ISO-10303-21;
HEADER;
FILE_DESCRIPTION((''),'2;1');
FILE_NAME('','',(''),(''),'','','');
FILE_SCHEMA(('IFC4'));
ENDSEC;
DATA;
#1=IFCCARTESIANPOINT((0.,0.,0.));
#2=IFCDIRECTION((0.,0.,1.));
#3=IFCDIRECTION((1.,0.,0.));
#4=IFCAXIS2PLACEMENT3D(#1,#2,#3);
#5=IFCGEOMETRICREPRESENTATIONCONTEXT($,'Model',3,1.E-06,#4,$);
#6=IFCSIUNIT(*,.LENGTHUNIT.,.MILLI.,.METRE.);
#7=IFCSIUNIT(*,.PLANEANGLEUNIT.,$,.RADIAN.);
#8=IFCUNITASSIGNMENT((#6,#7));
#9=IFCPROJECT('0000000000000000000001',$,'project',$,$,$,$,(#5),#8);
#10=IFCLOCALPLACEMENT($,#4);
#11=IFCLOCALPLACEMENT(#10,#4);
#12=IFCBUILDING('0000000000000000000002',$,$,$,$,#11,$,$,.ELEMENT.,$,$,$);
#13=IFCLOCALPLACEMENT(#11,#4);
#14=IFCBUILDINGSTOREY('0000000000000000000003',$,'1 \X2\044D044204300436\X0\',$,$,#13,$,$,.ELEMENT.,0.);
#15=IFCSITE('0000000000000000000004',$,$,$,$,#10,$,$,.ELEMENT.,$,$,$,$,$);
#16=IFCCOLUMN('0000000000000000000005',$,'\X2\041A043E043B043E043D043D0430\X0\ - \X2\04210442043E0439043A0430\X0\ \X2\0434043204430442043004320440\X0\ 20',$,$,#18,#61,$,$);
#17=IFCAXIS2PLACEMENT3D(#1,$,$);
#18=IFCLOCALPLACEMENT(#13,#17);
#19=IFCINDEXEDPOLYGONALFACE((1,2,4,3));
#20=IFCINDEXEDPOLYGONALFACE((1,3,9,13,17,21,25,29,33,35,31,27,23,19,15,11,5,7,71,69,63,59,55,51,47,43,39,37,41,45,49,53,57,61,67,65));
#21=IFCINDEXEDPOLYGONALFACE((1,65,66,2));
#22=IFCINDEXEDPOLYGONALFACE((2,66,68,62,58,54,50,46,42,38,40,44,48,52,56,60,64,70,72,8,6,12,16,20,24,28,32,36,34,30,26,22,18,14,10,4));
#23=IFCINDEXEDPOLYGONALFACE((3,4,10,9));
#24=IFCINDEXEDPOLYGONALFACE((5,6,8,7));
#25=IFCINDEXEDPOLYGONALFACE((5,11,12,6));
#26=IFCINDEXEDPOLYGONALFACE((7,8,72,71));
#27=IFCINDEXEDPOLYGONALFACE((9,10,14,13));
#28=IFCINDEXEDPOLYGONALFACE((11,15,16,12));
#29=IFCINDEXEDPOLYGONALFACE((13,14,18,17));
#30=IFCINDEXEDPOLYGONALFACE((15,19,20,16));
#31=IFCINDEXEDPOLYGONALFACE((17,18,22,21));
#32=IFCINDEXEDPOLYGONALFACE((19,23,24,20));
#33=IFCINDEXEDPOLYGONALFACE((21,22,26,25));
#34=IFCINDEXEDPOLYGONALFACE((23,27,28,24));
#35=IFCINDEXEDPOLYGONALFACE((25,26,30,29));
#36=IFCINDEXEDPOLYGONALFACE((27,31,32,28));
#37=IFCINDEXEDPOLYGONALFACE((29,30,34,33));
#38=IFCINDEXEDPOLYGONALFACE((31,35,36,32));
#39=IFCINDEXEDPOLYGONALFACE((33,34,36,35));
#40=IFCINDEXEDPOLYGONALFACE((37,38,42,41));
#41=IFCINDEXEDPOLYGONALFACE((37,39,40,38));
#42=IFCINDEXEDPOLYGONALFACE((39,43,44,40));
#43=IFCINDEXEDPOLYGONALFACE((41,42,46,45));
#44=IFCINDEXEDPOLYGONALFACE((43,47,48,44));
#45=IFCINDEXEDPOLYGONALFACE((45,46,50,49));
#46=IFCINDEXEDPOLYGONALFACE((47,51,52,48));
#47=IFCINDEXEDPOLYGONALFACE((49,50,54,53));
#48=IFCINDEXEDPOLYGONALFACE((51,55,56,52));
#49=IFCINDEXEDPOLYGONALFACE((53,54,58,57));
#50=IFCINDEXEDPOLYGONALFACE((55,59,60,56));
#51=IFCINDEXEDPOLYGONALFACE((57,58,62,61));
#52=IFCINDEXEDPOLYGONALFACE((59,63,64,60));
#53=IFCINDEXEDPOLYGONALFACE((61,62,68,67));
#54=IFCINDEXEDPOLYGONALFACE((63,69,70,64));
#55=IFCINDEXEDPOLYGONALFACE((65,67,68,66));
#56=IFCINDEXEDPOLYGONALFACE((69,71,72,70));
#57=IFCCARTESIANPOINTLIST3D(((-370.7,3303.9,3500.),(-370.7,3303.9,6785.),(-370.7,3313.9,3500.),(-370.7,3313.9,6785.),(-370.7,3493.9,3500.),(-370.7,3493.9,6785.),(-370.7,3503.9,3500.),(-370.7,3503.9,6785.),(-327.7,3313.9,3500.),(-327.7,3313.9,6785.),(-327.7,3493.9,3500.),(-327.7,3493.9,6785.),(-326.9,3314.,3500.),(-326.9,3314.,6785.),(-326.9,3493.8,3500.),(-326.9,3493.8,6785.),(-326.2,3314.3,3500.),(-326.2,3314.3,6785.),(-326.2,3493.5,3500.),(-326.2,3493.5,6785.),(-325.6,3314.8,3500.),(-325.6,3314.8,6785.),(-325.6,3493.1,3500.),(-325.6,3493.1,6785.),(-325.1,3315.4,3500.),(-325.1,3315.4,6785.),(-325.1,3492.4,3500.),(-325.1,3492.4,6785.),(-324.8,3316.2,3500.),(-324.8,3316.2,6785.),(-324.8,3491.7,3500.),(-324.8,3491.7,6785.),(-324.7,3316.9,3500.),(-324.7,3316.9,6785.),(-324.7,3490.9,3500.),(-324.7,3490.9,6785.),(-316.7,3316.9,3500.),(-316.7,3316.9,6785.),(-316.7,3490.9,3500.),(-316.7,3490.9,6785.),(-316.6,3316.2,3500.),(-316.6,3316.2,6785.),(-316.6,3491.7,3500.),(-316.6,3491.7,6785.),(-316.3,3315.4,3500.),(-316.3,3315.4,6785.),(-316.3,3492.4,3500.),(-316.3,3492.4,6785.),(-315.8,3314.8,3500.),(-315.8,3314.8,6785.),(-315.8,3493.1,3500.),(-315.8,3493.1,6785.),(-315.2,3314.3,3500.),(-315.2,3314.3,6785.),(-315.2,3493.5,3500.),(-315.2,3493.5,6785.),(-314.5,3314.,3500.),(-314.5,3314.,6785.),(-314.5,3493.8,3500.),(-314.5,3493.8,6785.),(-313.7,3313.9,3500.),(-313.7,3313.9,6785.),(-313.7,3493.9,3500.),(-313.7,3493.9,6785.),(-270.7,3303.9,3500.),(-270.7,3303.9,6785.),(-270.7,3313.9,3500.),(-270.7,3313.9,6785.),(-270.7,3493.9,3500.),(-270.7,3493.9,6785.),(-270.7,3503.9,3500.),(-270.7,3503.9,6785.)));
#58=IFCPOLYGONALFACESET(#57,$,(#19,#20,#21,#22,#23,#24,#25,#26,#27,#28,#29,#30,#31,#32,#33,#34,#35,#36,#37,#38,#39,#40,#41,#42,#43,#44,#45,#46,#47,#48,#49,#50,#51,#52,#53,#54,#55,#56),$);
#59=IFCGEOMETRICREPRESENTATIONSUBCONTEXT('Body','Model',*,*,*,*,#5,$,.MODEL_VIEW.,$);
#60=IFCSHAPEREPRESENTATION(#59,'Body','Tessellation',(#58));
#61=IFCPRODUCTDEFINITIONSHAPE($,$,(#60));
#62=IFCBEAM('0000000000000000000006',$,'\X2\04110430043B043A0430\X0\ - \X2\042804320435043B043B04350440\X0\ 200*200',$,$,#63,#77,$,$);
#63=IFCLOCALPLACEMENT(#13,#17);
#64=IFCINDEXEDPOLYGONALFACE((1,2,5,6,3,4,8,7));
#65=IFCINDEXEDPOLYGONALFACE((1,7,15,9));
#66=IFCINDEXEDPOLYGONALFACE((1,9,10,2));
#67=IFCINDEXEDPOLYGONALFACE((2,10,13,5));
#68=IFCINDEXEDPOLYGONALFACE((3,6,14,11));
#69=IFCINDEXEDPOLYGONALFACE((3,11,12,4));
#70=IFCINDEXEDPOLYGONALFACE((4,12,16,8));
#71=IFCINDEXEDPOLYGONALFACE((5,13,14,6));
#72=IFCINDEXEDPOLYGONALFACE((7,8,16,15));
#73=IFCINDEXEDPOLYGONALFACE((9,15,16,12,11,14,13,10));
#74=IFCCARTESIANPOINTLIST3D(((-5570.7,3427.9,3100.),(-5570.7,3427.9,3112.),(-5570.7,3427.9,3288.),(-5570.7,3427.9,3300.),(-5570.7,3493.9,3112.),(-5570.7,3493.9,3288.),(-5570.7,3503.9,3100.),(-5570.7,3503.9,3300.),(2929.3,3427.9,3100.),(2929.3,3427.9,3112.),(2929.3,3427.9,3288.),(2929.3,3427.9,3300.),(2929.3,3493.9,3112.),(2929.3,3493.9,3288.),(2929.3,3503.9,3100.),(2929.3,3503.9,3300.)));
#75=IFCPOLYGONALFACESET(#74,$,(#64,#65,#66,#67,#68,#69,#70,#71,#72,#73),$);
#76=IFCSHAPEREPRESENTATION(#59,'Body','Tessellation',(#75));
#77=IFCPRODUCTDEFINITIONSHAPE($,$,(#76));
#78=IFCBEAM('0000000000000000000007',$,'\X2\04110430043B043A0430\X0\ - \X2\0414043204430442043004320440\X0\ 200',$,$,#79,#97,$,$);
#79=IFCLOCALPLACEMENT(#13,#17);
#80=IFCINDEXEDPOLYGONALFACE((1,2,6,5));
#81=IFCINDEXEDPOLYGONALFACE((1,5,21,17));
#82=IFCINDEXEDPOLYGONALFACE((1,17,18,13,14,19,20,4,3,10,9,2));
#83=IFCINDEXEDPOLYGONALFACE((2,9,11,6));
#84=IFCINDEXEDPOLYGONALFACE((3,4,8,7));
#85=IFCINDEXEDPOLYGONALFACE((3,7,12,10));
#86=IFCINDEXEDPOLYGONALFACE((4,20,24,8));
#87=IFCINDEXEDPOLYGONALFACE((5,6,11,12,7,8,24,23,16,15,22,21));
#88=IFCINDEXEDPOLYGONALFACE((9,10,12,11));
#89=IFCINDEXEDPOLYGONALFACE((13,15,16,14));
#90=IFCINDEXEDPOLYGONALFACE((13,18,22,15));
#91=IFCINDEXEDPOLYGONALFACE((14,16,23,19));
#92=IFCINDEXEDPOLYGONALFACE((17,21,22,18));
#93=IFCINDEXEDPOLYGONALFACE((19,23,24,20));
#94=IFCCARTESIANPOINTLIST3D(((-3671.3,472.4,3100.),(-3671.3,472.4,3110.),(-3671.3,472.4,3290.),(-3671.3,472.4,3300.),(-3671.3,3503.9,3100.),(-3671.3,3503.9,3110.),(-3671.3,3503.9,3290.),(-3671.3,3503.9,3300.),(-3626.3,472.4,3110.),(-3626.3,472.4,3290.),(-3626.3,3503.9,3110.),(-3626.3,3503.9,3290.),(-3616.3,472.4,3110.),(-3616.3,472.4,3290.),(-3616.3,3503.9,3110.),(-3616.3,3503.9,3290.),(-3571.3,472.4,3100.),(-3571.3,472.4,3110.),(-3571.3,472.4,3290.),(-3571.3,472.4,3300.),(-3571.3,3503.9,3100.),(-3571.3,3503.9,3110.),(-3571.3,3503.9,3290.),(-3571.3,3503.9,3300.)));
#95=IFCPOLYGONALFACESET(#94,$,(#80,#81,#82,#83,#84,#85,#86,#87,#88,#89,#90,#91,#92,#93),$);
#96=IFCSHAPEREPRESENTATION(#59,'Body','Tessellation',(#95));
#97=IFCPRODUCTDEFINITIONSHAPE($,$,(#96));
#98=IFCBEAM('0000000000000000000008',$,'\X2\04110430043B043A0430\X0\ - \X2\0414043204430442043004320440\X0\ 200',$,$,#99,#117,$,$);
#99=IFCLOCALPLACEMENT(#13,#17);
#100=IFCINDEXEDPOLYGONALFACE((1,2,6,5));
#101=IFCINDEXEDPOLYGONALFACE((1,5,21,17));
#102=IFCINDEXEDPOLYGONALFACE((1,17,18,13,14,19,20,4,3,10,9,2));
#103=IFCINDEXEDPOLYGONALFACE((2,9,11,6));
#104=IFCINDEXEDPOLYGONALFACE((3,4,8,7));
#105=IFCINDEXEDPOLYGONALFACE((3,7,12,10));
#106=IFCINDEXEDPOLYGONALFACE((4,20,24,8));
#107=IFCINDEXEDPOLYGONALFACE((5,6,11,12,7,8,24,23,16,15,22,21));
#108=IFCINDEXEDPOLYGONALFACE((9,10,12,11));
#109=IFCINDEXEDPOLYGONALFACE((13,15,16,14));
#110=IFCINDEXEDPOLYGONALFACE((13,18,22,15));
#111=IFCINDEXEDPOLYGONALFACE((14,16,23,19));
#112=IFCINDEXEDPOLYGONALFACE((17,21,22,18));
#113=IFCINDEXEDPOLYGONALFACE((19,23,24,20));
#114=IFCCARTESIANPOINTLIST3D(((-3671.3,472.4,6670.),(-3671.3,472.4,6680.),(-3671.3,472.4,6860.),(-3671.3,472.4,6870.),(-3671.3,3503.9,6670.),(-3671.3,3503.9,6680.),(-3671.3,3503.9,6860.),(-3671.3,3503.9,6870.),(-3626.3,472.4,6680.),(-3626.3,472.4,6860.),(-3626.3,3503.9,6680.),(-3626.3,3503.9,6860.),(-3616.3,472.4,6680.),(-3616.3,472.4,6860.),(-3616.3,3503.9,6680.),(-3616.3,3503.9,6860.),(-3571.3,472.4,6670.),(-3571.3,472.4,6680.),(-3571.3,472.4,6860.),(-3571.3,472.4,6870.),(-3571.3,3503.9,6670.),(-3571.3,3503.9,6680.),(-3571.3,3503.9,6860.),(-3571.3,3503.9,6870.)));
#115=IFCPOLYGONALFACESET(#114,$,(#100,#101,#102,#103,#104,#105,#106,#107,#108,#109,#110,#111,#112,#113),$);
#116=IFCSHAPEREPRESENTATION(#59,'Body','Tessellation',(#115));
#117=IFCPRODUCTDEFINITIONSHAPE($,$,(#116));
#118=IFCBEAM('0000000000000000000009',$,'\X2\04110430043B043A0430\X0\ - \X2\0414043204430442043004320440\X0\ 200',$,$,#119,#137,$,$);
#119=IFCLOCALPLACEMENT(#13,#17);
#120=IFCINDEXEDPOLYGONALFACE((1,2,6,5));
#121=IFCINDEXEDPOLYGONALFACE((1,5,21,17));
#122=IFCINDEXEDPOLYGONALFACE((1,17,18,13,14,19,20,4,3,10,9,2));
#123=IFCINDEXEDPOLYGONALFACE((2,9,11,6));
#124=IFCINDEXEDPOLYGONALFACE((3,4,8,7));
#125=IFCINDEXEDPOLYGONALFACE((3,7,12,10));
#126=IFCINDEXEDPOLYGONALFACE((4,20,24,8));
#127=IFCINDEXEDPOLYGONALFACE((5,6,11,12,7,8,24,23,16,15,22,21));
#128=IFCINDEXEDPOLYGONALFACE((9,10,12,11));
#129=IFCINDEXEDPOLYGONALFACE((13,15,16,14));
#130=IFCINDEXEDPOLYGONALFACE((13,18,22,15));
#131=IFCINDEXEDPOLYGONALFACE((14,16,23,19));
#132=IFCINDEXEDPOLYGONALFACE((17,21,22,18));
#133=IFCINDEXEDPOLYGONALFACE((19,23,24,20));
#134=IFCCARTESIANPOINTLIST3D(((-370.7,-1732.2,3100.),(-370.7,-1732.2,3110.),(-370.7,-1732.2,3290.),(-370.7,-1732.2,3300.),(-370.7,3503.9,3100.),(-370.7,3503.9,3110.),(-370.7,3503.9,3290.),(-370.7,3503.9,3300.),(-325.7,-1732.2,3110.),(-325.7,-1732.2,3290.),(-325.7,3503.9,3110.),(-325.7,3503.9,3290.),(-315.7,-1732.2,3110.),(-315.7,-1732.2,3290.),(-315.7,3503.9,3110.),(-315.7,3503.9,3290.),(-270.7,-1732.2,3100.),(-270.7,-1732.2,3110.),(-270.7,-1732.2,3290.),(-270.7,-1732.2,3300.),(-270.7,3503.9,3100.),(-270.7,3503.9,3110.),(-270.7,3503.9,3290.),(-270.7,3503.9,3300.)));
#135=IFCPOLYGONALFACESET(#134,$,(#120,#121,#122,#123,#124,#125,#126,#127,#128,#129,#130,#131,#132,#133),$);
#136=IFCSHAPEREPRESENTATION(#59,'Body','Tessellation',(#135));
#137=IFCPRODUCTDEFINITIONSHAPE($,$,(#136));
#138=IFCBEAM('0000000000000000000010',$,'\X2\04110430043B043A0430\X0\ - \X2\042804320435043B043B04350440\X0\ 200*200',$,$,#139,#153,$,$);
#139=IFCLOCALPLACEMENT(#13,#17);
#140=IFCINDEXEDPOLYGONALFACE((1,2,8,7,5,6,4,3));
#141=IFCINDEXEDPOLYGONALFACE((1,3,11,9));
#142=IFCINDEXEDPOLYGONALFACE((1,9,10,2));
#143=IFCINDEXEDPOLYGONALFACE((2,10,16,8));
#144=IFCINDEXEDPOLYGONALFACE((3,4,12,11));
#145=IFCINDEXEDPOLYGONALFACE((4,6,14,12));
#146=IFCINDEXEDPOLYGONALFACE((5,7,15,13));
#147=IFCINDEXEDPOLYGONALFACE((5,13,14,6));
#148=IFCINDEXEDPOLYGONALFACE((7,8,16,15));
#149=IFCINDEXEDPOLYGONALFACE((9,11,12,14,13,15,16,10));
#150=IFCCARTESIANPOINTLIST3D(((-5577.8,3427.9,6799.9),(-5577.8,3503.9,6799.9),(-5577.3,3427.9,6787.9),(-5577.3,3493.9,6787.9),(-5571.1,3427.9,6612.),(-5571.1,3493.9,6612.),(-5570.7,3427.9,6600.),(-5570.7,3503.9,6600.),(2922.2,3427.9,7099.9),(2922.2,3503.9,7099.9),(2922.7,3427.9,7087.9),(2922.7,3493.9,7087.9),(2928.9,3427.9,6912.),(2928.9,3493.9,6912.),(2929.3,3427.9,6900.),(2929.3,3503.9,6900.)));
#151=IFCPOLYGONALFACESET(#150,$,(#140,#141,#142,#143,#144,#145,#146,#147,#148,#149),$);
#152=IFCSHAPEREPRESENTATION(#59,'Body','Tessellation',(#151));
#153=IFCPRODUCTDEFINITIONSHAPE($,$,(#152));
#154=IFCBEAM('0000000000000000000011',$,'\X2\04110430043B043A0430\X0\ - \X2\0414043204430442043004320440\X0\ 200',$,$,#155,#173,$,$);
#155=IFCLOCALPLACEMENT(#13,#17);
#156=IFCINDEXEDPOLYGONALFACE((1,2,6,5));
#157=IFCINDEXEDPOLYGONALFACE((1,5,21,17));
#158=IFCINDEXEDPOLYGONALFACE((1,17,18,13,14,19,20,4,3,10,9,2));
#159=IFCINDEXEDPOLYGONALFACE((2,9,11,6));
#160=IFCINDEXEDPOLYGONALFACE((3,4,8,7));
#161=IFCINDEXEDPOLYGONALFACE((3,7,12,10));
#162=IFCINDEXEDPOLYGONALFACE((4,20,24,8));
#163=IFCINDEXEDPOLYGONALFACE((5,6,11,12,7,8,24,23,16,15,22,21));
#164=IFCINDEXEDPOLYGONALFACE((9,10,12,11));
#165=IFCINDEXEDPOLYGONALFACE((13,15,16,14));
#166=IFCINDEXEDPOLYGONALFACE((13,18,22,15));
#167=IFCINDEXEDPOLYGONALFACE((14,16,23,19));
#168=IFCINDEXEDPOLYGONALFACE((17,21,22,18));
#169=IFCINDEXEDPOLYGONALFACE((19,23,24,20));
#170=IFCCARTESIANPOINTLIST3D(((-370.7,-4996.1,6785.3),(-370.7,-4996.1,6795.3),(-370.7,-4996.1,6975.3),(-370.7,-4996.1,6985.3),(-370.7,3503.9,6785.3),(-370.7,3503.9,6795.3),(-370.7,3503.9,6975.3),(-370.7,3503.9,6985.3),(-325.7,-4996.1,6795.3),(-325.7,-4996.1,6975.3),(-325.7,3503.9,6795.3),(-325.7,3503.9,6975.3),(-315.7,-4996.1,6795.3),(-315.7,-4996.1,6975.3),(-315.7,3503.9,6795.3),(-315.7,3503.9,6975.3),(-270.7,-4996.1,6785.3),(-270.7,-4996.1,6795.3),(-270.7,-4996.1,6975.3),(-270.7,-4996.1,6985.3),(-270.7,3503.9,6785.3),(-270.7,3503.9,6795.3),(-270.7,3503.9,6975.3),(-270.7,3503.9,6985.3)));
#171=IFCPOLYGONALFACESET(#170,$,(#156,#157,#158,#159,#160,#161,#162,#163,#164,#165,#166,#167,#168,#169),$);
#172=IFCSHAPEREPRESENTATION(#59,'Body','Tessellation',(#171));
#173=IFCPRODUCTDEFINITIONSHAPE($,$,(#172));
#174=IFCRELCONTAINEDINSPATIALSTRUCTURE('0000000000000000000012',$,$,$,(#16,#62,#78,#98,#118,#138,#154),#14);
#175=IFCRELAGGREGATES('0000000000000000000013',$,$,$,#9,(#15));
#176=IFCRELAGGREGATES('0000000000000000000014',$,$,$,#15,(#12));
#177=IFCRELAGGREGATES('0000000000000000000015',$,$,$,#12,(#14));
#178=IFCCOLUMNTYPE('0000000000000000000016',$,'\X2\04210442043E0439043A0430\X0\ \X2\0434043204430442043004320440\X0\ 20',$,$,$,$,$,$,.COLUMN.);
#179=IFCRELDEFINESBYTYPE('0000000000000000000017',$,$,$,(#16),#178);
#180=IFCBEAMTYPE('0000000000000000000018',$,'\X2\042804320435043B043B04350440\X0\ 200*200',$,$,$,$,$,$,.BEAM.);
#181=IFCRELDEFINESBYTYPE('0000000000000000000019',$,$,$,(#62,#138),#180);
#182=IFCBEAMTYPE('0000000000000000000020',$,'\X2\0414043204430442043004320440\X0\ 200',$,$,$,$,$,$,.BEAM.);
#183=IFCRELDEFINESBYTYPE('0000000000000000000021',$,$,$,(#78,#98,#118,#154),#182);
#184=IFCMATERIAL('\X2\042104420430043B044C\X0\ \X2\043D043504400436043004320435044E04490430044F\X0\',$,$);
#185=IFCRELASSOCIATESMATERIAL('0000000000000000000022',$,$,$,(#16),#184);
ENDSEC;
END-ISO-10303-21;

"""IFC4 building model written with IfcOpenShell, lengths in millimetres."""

from ifc_helpers import new_model, si_unit, frame, origin_with_axes, place, context, subcontext, project, spatial, line, arc, indexed_curve, outline, extrude, source, transform, mapped, material, type_object, element, save


model = new_model("IFC4")

# Units and contexts
model_context = context("Model", 3, precision=1e-06, world=origin_with_axes())
body_context = subcontext(model_context, "Body", "Model", "MODEL_VIEW")
ifc_project = project(units=[si_unit("LENGTHUNIT", "METRE", prefix="MILLI"), si_unit("PLANEANGLEUNIT", "RADIAN")], contexts=[model_context])

# Site, building, storey
site_placement = place(None, origin_with_axes())
site = spatial("IfcSite", under=ifc_project, at=site_placement, CompositionType="ELEMENT")
building_placement = place(site_placement, origin_with_axes())
building = spatial("IfcBuilding", under=site, at=building_placement, CompositionType="ELEMENT")
storey_placement = place(building_placement, origin_with_axes())
storey = spatial("IfcBuildingStorey", under=building, at=storey_placement, Name="1 этаж", CompositionType="ELEMENT", Elevation=0.0)

# Column
ifc_material_1 = material(Name="Сталь нержавеющая")
column_type = type_object("IfcColumnType", Name="Стойка двутавр 20", PredefinedType="COLUMN")
shared_shape_1 = source(origin_with_axes(), body_context, "Body", "SweptSolid", [
    extrude(outline(indexed_curve([(-50.0, -100.0), (50.0, -100.0), (50.0, -90.0), (7.0, -90.0), (4.9, -89.1), (4.0, -87.0), (4.0, 87.0), (4.9, 89.1), (7.0, 90.0), (50.0, 90.0), (50.0, 100.0), (-50.0, 100.0), (-50.0, 90.0), (-7.0, 90.0), (-4.9, 89.1), (-4.0, 87.0), (-4.0, -87.0), (-4.9, -89.1), (-7.0, -90.0), (-50.0, -90.0)], segments=[line(1, 2), line(2, 3), line(3, 4), arc(4, 5, 6), line(6, 7), arc(7, 8, 9), line(9, 10), line(10, 11), line(11, 12), line(12, 13), line(13, 14), arc(14, 15, 16), line(16, 17), arc(17, 18, 19), line(19, 20), line(20, 1)])), origin_with_axes(), (0.0, 0.0, 1.0), 3285.0),
])
column_1_placement = place(storey_placement, frame((-320.7, 3403.9, 3500.0), z_axis=(0.0, 0.0, 1.0), x_axis=(1.0, 0.0, 0.0)))
element("IfcColumn", 1, at=column_1_placement, inside=storey, type_object=column_type, material=ifc_material_1, Name="Колонна - Стойка двутавр 20", context=body_context, shape_type="MappedRepresentation", body=[
    mapped(shared_shape_1, transform((0.0, 0.0, 0.0), x_axis=(1.0, 0.0, 0.0), y_axis=(0.0, 1.0, 0.0), z_axis=(0.0, 0.0, 1.0), scale=1.0)),
])

# Beams
beam_type_1 = type_object("IfcBeamType", Name="Швеллер 200*200", PredefinedType="BEAM")
shared_shape_2 = source(origin_with_axes(), body_context, "Body", "SweptSolid", [
    extrude(outline(indexed_curve([(0.0, 0.0), (76.0, 0.0), (76.0, 12.0), (10.0, 12.0), (10.0, 188.0), (76.0, 188.0), (76.0, 200.0), (0.0, 200.0)], segments=[line(1, 2), line(2, 3), line(3, 4), line(4, 5), line(5, 6), line(6, 7), line(7, 8), line(8, 1)])), origin_with_axes(), (0.0, 0.0, -1.0), 8500.0),
])
beam_1_placement = place(storey_placement, frame((-5570.7, 3503.9, 3100.0), z_axis=(-1.0, 0.0, 0.0), x_axis=(0.0, -1.0, 0.0)))
element("IfcBeam", 2, at=beam_1_placement, inside=storey, type_object=beam_type_1, Name="Балка - Швеллер 200*200", context=body_context, shape_type="MappedRepresentation", body=[
    mapped(shared_shape_2, transform((0.0, 0.0, 0.0), x_axis=(1.0, 0.0, 0.0), y_axis=(0.0, 1.0, 0.0), z_axis=(0.0, 0.0, 1.0), scale=1.0)),
])
beam_type_2 = type_object("IfcBeamType", Name="Двутавр 200", PredefinedType="BEAM")
shared_shape_3 = source(origin_with_axes(), body_context, "Body", "SweptSolid", [
    extrude(outline(indexed_curve([(-50.0, 0.0), (50.0, 0.0), (50.0, 10.0), (5.0, 10.0), (5.0, 190.0), (50.0, 190.0), (50.0, 200.0), (-50.0, 200.0), (-50.0, 190.0), (-5.0, 190.0), (-5.0, 10.0), (-50.0, 10.0)], segments=[line(1, 2), line(2, 3), line(3, 4), line(4, 5), line(5, 6), line(6, 7), line(7, 8), line(8, 9), line(9, 10), line(10, 11), line(11, 12), line(12, 1)])), origin_with_axes(), (0.0, 0.0, -1.0), 3031.6),
])
for number, where, z_axis, x_axis, name in (
    (3, (-3621.3, 3503.9, 3100.0), (0.0, 1.0, 0.0), (-1.0, 0.0, 0.0), "Балка - Двутавр 200"),
    (4, (-3621.3, 3503.9, 6670.0), (0.0, 1.0, 0.0), (-1.0, 0.0, 0.0), "Балка - Двутавр 200"),
):
    element("IfcBeam", number, at=place(storey_placement, frame(where, z_axis=z_axis, x_axis=x_axis)), inside=storey, type_object=beam_type_2, Name=name, context=body_context, shape_type="MappedRepresentation", body=[
        mapped(shared_shape_3, transform((0.0, 0.0, 0.0), x_axis=(1.0, 0.0, 0.0), y_axis=(0.0, 1.0, 0.0), z_axis=(0.0, 0.0, 1.0), scale=1.0)),
    ])
shared_shape_4 = source(origin_with_axes(), body_context, "Body", "SweptSolid", [
    extrude(outline(indexed_curve([(-50.0, 0.0), (50.0, 0.0), (50.0, 10.0), (5.0, 10.0), (5.0, 190.0), (50.0, 190.0), (50.0, 200.0), (-50.0, 200.0), (-50.0, 190.0), (-5.0, 190.0), (-5.0, 10.0), (-50.0, 10.0)], segments=[line(1, 2), line(2, 3), line(3, 4), line(4, 5), line(5, 6), line(6, 7), line(7, 8), line(8, 9), line(9, 10), line(10, 11), line(11, 12), line(12, 1)])), origin_with_axes(), (0.0, 0.0, -1.0), 5236.1),
])
beam_2_placement = place(storey_placement, frame((-320.7, 3503.9, 3100.0), z_axis=(0.0, 1.0, 0.0), x_axis=(-1.0, 0.0, 0.0)))
element("IfcBeam", 5, at=beam_2_placement, inside=storey, type_object=beam_type_2, Name="Балка - Двутавр 200", context=body_context, shape_type="MappedRepresentation", body=[
    mapped(shared_shape_4, transform((0.0, 0.0, 0.0), x_axis=(1.0, 0.0, 0.0), y_axis=(0.0, 1.0, 0.0), z_axis=(0.0, 0.0, 1.0), scale=1.0)),
])
shared_shape_5 = source(origin_with_axes(), body_context, "Body", "SweptSolid", [
    extrude(outline(indexed_curve([(0.0, 0.0), (76.0, 0.0), (76.0, 12.0), (10.0, 12.0), (10.0, 188.0), (76.0, 188.0), (76.0, 200.0), (0.0, 200.0)], segments=[line(1, 2), line(2, 3), line(3, 4), line(4, 5), line(5, 6), line(6, 7), line(7, 8), line(8, 1)])), origin_with_axes(), (0.0, 0.0, -1.0), 8505.3),
])
beam_3_placement = place(storey_placement, frame((-5570.7, 3503.9, 6600.0), z_axis=(-0.999378, 0.0, -0.035272), x_axis=(0.0, -1.0, 0.0)))
element("IfcBeam", 6, at=beam_3_placement, inside=storey, type_object=beam_type_1, Name="Балка - Швеллер 200*200", context=body_context, shape_type="MappedRepresentation", body=[
    mapped(shared_shape_5, transform((0.0, 0.0, 0.0), x_axis=(1.0, 0.0, 0.0), y_axis=(0.0, 1.0, 0.0), z_axis=(0.0, 0.0, 1.0), scale=1.0)),
])
shared_shape_6 = source(origin_with_axes(), body_context, "Body", "SweptSolid", [
    extrude(outline(indexed_curve([(-50.0, 0.0), (50.0, 0.0), (50.0, 10.0), (5.0, 10.0), (5.0, 190.0), (50.0, 190.0), (50.0, 200.0), (-50.0, 200.0), (-50.0, 190.0), (-5.0, 190.0), (-5.0, 10.0), (-50.0, 10.0)], segments=[line(1, 2), line(2, 3), line(3, 4), line(4, 5), line(5, 6), line(6, 7), line(7, 8), line(8, 9), line(9, 10), line(10, 11), line(11, 12), line(12, 1)])), origin_with_axes(), (0.0, 0.0, -1.0), 8500.0),
])
beam_4_placement = place(storey_placement, frame((-320.7, 3503.9, 6785.3), z_axis=(0.0, 1.0, 0.0), x_axis=(-1.0, 0.0, 0.0)))
element("IfcBeam", 7, at=beam_4_placement, inside=storey, type_object=beam_type_2, Name="Балка - Двутавр 200", context=body_context, shape_type="MappedRepresentation", body=[
    mapped(shared_shape_6, transform((0.0, 0.0, 0.0), x_axis=(1.0, 0.0, 0.0), y_axis=(0.0, 1.0, 0.0), z_axis=(0.0, 0.0, 1.0), scale=1.0)),
])

save(model, "model.ifc")
